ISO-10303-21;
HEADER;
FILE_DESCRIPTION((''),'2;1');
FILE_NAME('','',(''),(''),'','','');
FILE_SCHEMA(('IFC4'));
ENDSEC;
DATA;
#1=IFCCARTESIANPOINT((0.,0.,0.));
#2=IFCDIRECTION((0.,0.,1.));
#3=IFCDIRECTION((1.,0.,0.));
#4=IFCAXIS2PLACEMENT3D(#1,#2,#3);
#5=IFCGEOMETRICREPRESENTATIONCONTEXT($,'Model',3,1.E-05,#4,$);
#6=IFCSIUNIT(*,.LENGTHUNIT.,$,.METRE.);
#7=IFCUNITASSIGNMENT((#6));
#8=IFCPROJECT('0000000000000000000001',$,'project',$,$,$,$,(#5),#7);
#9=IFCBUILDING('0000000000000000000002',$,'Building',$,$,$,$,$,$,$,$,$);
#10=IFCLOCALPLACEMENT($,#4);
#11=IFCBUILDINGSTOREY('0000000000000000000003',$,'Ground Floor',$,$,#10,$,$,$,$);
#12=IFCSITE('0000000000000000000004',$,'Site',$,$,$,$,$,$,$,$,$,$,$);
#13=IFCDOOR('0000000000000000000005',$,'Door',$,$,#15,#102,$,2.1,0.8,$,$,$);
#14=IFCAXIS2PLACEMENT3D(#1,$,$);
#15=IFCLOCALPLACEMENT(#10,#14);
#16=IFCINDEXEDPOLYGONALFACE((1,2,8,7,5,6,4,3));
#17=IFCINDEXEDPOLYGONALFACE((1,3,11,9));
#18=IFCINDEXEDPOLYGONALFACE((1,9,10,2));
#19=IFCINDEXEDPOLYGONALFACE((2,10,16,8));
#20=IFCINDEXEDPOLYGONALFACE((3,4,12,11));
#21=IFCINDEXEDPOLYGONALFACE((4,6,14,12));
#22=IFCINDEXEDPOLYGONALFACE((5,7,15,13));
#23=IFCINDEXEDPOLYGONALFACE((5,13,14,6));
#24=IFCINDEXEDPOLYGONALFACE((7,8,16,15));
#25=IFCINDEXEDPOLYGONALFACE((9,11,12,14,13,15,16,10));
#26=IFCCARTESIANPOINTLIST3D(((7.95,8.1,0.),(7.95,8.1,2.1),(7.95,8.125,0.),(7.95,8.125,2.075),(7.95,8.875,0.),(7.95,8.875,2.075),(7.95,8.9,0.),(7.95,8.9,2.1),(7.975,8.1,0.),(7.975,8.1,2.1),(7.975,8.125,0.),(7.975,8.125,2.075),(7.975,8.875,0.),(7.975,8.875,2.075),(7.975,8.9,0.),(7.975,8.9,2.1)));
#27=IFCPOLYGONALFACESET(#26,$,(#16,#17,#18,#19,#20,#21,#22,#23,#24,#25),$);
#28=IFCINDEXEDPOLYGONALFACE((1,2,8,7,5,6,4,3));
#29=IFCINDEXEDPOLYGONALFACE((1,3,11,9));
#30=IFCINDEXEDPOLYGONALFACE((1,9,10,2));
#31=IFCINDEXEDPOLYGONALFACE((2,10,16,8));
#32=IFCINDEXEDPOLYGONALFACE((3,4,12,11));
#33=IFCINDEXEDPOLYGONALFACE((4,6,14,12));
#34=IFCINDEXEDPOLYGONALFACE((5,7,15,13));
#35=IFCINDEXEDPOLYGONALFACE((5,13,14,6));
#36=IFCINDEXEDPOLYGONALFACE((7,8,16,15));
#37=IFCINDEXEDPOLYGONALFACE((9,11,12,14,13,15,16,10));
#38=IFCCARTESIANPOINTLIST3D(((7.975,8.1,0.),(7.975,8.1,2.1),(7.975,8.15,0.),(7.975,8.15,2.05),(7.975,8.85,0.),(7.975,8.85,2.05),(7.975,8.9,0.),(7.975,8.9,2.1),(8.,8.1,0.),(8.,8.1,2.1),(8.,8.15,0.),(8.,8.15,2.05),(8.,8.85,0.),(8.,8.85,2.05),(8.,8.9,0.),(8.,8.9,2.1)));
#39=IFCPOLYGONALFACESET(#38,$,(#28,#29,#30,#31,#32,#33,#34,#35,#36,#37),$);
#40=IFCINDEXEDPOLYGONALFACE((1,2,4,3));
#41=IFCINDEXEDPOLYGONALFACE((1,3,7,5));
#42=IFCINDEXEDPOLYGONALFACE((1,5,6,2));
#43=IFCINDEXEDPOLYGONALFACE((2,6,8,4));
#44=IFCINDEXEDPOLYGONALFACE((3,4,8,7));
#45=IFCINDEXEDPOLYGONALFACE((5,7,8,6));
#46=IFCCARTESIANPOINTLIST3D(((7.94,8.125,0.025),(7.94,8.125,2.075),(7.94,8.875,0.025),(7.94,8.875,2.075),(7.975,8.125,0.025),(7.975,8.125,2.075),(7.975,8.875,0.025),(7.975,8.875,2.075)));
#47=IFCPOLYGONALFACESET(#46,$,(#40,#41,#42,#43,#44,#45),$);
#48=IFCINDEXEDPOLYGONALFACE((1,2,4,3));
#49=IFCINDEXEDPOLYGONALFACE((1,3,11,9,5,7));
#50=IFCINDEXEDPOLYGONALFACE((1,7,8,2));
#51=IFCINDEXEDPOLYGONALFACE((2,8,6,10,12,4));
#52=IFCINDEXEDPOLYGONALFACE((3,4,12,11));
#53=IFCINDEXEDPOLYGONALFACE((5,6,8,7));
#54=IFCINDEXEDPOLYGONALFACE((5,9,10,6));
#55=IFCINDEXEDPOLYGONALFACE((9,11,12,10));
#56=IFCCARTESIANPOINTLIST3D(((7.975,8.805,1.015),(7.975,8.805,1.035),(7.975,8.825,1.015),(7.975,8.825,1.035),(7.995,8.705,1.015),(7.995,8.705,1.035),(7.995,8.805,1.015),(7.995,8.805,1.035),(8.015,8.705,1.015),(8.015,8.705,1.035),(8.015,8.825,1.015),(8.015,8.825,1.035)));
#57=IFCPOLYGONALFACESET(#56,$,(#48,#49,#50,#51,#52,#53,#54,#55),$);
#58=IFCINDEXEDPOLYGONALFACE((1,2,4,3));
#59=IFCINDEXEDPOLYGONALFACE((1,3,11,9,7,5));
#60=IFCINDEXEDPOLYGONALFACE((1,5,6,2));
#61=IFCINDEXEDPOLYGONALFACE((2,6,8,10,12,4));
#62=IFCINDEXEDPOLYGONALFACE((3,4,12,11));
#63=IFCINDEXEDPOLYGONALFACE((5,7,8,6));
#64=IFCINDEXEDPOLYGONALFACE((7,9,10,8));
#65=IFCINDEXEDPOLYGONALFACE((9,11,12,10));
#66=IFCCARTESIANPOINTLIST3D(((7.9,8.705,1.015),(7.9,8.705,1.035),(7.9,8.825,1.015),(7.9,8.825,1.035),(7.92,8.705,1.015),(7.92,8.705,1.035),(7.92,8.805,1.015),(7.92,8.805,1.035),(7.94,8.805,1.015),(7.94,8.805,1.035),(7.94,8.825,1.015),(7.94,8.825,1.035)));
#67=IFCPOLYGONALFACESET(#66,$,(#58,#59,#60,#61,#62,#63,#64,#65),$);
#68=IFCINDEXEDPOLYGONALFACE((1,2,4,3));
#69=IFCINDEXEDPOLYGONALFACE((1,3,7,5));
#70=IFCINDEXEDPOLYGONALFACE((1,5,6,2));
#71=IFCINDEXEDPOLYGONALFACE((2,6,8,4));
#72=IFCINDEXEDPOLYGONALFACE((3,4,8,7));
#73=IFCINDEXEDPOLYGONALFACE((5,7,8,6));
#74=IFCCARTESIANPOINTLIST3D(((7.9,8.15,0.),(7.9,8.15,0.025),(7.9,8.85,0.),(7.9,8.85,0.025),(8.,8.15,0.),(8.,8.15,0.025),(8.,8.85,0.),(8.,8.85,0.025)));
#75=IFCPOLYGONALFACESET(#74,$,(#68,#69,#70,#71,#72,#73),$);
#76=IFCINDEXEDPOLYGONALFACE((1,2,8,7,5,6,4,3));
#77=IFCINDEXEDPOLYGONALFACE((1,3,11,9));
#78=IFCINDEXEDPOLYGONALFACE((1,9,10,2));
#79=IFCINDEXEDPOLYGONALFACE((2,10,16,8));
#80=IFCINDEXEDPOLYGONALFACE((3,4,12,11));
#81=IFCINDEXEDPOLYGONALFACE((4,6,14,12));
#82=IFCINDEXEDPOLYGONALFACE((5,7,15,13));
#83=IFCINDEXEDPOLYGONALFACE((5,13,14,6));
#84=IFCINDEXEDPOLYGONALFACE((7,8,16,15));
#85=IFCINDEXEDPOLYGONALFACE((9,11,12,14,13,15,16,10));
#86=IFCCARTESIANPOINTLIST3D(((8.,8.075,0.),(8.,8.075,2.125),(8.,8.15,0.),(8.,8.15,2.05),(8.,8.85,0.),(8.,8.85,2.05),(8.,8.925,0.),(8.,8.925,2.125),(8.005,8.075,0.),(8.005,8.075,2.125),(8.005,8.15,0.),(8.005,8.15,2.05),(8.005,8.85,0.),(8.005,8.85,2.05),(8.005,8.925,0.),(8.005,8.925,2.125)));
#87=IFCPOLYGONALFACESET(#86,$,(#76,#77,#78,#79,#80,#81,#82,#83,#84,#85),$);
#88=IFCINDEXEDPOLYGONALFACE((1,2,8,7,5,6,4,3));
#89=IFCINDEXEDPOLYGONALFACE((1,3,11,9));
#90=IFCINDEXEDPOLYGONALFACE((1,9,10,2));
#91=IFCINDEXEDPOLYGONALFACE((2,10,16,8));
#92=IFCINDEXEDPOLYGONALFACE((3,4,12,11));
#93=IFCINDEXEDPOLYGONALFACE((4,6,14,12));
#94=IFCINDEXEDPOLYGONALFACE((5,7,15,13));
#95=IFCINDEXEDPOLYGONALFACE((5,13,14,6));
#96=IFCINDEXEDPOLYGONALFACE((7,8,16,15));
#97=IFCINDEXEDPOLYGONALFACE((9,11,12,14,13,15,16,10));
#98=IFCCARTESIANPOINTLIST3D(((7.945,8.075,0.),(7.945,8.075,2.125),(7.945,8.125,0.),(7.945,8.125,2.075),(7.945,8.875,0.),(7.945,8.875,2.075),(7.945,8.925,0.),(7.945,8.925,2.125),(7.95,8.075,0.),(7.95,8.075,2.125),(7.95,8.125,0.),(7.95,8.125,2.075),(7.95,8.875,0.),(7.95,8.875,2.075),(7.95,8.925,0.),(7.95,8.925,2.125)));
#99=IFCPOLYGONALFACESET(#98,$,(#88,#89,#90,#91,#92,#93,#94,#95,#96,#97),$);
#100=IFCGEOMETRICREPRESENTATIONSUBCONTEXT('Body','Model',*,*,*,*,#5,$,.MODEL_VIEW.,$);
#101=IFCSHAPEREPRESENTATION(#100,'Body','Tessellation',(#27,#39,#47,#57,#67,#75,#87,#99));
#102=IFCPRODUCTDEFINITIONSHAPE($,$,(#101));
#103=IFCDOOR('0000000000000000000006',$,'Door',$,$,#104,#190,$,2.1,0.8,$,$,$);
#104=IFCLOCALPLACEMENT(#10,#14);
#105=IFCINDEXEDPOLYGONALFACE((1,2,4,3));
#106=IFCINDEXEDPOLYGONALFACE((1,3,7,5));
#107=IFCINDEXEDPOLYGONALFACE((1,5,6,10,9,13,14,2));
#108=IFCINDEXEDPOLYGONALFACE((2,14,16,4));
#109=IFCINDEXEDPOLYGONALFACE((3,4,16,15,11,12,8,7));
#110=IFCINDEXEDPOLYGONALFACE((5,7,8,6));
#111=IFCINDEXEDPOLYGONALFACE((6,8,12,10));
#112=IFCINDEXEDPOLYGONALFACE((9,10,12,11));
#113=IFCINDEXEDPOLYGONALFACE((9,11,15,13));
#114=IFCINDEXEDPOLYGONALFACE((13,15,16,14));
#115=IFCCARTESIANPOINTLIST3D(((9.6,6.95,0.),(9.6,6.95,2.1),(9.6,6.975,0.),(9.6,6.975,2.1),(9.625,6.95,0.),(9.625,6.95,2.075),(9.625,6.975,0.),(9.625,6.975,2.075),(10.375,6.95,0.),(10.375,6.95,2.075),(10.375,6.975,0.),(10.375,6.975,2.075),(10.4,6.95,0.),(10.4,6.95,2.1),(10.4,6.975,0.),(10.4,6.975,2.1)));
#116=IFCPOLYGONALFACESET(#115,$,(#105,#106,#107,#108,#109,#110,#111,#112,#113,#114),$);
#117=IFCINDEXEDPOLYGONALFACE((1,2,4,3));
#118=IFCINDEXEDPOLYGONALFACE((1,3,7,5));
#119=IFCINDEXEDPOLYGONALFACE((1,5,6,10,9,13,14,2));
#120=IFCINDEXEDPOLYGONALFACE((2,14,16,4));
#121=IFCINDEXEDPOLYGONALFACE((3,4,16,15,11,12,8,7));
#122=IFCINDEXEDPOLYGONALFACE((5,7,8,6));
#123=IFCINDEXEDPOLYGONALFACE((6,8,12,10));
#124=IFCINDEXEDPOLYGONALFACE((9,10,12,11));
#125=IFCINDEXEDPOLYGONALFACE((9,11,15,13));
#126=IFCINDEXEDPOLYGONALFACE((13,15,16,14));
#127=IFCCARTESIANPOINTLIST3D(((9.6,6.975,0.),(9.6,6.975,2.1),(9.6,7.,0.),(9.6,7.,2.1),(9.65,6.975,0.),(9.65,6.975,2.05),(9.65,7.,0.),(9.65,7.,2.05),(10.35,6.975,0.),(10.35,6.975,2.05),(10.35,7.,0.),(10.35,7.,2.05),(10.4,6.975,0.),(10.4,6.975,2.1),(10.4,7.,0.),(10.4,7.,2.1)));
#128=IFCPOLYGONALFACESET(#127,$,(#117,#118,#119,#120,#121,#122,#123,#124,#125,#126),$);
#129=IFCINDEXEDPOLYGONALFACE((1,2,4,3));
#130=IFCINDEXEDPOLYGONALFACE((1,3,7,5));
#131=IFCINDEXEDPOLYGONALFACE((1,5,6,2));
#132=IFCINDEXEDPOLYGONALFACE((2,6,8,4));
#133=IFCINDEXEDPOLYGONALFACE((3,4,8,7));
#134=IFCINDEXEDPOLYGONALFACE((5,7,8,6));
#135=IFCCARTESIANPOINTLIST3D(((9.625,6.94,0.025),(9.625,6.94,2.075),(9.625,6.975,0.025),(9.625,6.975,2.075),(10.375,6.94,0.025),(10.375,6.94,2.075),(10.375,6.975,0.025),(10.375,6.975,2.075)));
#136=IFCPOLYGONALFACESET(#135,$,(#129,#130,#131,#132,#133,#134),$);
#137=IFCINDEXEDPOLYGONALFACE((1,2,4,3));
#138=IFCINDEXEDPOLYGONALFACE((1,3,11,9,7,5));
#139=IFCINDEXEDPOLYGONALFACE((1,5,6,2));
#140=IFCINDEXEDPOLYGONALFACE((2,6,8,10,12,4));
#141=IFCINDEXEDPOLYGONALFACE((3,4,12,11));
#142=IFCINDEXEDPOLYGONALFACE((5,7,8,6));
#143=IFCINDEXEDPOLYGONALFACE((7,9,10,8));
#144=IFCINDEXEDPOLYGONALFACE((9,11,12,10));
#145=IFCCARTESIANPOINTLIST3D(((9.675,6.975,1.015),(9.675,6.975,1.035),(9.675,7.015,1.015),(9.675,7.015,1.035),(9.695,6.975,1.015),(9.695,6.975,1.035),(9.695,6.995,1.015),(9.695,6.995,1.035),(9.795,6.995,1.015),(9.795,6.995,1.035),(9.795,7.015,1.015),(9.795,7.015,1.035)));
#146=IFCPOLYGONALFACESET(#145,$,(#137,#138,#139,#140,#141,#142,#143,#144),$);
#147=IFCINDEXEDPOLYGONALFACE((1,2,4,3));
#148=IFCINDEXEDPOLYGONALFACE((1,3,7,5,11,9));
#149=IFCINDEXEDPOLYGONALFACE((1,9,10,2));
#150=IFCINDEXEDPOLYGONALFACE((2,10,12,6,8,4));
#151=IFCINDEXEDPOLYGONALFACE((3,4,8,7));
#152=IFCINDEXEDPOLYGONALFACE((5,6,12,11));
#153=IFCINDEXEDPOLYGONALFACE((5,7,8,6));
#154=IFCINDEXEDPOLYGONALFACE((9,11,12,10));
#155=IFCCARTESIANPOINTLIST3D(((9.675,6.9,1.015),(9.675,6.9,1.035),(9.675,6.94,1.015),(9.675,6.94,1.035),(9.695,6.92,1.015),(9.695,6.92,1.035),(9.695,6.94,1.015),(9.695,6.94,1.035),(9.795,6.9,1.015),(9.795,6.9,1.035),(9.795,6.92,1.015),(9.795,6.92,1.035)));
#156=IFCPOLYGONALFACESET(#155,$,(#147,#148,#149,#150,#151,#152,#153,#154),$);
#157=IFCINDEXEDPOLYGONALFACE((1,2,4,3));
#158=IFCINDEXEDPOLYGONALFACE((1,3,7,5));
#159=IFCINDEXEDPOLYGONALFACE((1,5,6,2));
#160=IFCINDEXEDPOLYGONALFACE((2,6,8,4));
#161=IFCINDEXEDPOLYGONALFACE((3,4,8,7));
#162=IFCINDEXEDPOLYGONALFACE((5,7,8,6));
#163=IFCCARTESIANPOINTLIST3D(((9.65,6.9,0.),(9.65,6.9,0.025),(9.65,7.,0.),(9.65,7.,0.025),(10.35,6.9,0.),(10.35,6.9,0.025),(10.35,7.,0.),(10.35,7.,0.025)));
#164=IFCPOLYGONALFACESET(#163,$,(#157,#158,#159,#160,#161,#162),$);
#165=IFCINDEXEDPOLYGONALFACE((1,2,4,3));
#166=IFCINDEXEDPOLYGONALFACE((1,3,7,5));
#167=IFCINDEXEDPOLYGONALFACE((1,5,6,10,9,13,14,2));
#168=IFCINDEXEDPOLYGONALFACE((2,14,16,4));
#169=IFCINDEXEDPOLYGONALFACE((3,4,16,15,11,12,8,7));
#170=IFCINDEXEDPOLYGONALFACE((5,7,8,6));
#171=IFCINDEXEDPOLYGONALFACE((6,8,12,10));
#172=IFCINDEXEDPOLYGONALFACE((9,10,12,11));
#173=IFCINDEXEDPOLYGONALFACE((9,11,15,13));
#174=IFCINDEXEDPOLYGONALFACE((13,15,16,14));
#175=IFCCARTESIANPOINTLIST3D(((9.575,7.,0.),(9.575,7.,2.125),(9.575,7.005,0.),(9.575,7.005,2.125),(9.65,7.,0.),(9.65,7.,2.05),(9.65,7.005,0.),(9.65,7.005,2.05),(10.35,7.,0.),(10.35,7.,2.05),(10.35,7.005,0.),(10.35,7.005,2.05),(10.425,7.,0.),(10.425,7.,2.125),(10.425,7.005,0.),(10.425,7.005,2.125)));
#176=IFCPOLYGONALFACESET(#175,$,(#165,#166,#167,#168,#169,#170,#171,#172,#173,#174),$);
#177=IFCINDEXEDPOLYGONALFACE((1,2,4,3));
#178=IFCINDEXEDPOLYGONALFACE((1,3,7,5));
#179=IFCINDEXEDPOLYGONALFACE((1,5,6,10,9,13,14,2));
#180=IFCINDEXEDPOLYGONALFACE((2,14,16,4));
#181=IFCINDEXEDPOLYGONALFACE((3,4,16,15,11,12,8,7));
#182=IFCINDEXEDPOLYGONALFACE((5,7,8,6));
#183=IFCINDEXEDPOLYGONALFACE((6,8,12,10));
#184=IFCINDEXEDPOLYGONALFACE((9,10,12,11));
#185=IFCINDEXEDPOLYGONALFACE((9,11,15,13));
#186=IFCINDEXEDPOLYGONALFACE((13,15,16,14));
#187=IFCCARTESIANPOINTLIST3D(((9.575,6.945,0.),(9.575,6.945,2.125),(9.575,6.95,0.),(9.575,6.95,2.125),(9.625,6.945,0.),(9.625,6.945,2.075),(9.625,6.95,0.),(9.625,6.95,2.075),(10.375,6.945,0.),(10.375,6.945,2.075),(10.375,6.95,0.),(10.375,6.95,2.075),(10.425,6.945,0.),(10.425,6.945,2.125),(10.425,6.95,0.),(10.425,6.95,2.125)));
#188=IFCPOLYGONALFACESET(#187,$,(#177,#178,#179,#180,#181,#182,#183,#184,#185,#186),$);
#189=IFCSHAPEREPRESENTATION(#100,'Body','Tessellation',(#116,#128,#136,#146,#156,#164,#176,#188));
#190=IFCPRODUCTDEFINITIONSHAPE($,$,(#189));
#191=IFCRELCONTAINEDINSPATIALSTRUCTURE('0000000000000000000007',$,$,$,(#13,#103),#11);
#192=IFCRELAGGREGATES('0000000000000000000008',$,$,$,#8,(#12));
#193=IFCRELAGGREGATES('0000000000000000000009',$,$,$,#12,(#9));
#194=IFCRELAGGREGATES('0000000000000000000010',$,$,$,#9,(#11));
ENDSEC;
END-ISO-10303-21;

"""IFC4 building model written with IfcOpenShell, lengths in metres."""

from ifc_helpers import new_model, si_unit, frame, origin_with_axes, place, context, subcontext, project, spatial, line, indexed_curve, outline, extrude, element, save


model = new_model("IFC4")

# Units and contexts
model_context = context("Model", 3, precision=1e-05, world=origin_with_axes())
body_context = subcontext(model_context, "Body", "Model", "MODEL_VIEW")
ifc_project = project(units=[si_unit("LENGTHUNIT", "METRE")], contexts=[model_context])

# Site, building, storey
site = spatial("IfcSite", under=ifc_project, Name="Site")
building = spatial("IfcBuilding", under=site, Name="Building")
storey_placement = place(None, origin_with_axes())
storey = spatial("IfcBuildingStorey", under=building, at=storey_placement, Name="Ground Floor")

# Doors
door_1_placement = place(storey_placement, frame((8.0, 8.1, 0.0), z_axis=(0.0, 0.0, 1.0), x_axis=(0.0, 1.0, 0.0)))
element("IfcDoor", 1, at=door_1_placement, inside=storey, Name="Door", OverallHeight=2.1, OverallWidth=0.8, context=body_context, shape_type="SweptSolid", body=[
    extrude(outline(indexed_curve([(0.0, 0.0), (0.0, 2.1), (0.8, 2.1), (0.8, 0.0), (0.775, 0.0), (0.775, 2.075), (0.025, 2.075), (0.025, 0.0)], segments=[line(1, 2, 3, 4, 5, 6, 7, 8, 1)])), frame((0.0, 0.025, 0.0), z_axis=(0.0, -1.0, 0.0), x_axis=(1.0, 0.0, 0.0)), (0.0, 0.0, -1.0), 0.025),
    extrude(outline(indexed_curve([(0.0, 0.0), (0.0, 2.1), (0.8, 2.1), (0.8, 0.0), (0.75, 0.0), (0.75, 2.05), (0.05, 2.05), (0.05, 0.0)], segments=[line(1, 2, 3, 4, 5, 6, 7, 8, 1)])), frame((0.0, 0.0, 0.0), z_axis=(0.0, -1.0, 0.0), x_axis=(1.0, 0.0, 0.0)), (0.0, 0.0, -1.0), 0.025),
    extrude(outline(indexed_curve([(0.0, 0.0), (0.75, 0.0), (0.75, 0.035), (0.0, 0.035)], segments=[line(1, 2, 3, 4, 1)])), frame((0.025, 0.025, 0.025), z_axis=(0.0, 0.0, 1.0), x_axis=(1.0, 0.0, 0.0)), (0.0, 0.0, 1.0), 2.05),
    extrude(outline(indexed_curve([(0.0, 0.0), (0.0, -0.04), (-0.12, -0.04), (-0.12, -0.02), (-0.02, -0.02), (-0.02, 0.0)], segments=[line(1, 2, 3, 4, 5, 6, 1)])), frame((0.725, 0.025, 1.015), z_axis=(0.0, 0.0, 1.0), x_axis=(1.0, 0.0, 0.0)), (0.0, 0.0, 1.0), 0.02),
    extrude(outline(indexed_curve([(0.0, 0.0), (0.0, 0.04), (-0.12, 0.04), (-0.12, 0.02), (-0.02, 0.02), (-0.02, 0.0)], segments=[line(1, 2, 3, 4, 5, 6, 1)])), frame((0.725, 0.06, 1.015), z_axis=(0.0, 0.0, 1.0), x_axis=(1.0, 0.0, 0.0)), (0.0, 0.0, 1.0), 0.02),
    extrude(outline(indexed_curve([(0.0, 0.0), (0.7, 0.0), (0.7, 0.1), (0.0, 0.1)], segments=[line(1, 2, 3, 4, 1)])), frame((0.05, 0.0, 0.0), z_axis=(0.0, 0.0, 1.0), x_axis=(1.0, 0.0, 0.0)), (0.0, 0.0, 1.0), 0.025),
    extrude(outline(indexed_curve([(0.0, 0.0), (0.0, 2.125), (0.85, 2.125), (0.85, 0.0), (0.775, 0.0), (0.775, 2.05), (0.075, 2.05), (0.075, 0.0)], segments=[line(1, 2, 3, 4, 5, 6, 7, 8, 1)])), frame((-0.025, -0.005, 0.0), z_axis=(0.0, -1.0, 0.0), x_axis=(1.0, 0.0, 0.0)), (0.0, 0.0, -1.0), 0.005),
    extrude(outline(indexed_curve([(0.0, 0.0), (0.0, 2.125), (0.85, 2.125), (0.85, 0.0), (0.8, 0.0), (0.8, 2.075), (0.05, 2.075), (0.05, 0.0)], segments=[line(1, 2, 3, 4, 5, 6, 7, 8, 1)])), frame((-0.025, 0.05, 0.0), z_axis=(0.0, -1.0, 0.0), x_axis=(1.0, 0.0, 0.0)), (0.0, 0.0, -1.0), 0.005),
])
door_2_placement = place(storey_placement, frame((10.4, 7.0, 0.0), z_axis=(0.0, 0.0, 1.0), x_axis=(-1.0, 0.0, 0.0)))
element("IfcDoor", 2, at=door_2_placement, inside=storey, Name="Door", OverallHeight=2.1, OverallWidth=0.8, context=body_context, shape_type="SweptSolid", body=[
    extrude(outline(indexed_curve([(0.0, 0.0), (0.0, 2.1), (0.8, 2.1), (0.8, 0.0), (0.775, 0.0), (0.775, 2.075), (0.025, 2.075), (0.025, 0.0)], segments=[line(1, 2, 3, 4, 5, 6, 7, 8, 1)])), frame((0.0, 0.025, 0.0), z_axis=(0.0, -1.0, 0.0), x_axis=(1.0, 0.0, 0.0)), (0.0, 0.0, -1.0), 0.025),
    extrude(outline(indexed_curve([(0.0, 0.0), (0.0, 2.1), (0.8, 2.1), (0.8, 0.0), (0.75, 0.0), (0.75, 2.05), (0.05, 2.05), (0.05, 0.0)], segments=[line(1, 2, 3, 4, 5, 6, 7, 8, 1)])), frame((0.0, 0.0, 0.0), z_axis=(0.0, -1.0, 0.0), x_axis=(1.0, 0.0, 0.0)), (0.0, 0.0, -1.0), 0.025),
    extrude(outline(indexed_curve([(0.0, 0.0), (0.75, 0.0), (0.75, 0.035), (0.0, 0.035)], segments=[line(1, 2, 3, 4, 1)])), frame((0.025, 0.025, 0.025), z_axis=(0.0, 0.0, 1.0), x_axis=(1.0, 0.0, 0.0)), (0.0, 0.0, 1.0), 2.05),
    extrude(outline(indexed_curve([(0.0, 0.0), (0.0, -0.04), (-0.12, -0.04), (-0.12, -0.02), (-0.02, -0.02), (-0.02, 0.0)], segments=[line(1, 2, 3, 4, 5, 6, 1)])), frame((0.725, 0.025, 1.015), z_axis=(0.0, 0.0, 1.0), x_axis=(1.0, 0.0, 0.0)), (0.0, 0.0, 1.0), 0.02),
    extrude(outline(indexed_curve([(0.0, 0.0), (0.0, 0.04), (-0.12, 0.04), (-0.12, 0.02), (-0.02, 0.02), (-0.02, 0.0)], segments=[line(1, 2, 3, 4, 5, 6, 1)])), frame((0.725, 0.06, 1.015), z_axis=(0.0, 0.0, 1.0), x_axis=(1.0, 0.0, 0.0)), (0.0, 0.0, 1.0), 0.02),
    extrude(outline(indexed_curve([(0.0, 0.0), (0.7, 0.0), (0.7, 0.1), (0.0, 0.1)], segments=[line(1, 2, 3, 4, 1)])), frame((0.05, 0.0, 0.0), z_axis=(0.0, 0.0, 1.0), x_axis=(1.0, 0.0, 0.0)), (0.0, 0.0, 1.0), 0.025),
    extrude(outline(indexed_curve([(0.0, 0.0), (0.0, 2.125), (0.85, 2.125), (0.85, 0.0), (0.775, 0.0), (0.775, 2.05), (0.075, 2.05), (0.075, 0.0)], segments=[line(1, 2, 3, 4, 5, 6, 7, 8, 1)])), frame((-0.025, -0.005, 0.0), z_axis=(0.0, -1.0, 0.0), x_axis=(1.0, 0.0, 0.0)), (0.0, 0.0, -1.0), 0.005),
    extrude(outline(indexed_curve([(0.0, 0.0), (0.0, 2.125), (0.85, 2.125), (0.85, 0.0), (0.8, 0.0), (0.8, 2.075), (0.05, 2.075), (0.05, 0.0)], segments=[line(1, 2, 3, 4, 5, 6, 7, 8, 1)])), frame((-0.025, 0.05, 0.0), z_axis=(0.0, -1.0, 0.0), x_axis=(1.0, 0.0, 0.0)), (0.0, 0.0, -1.0), 0.005),
])

save(model, "model.ifc")
